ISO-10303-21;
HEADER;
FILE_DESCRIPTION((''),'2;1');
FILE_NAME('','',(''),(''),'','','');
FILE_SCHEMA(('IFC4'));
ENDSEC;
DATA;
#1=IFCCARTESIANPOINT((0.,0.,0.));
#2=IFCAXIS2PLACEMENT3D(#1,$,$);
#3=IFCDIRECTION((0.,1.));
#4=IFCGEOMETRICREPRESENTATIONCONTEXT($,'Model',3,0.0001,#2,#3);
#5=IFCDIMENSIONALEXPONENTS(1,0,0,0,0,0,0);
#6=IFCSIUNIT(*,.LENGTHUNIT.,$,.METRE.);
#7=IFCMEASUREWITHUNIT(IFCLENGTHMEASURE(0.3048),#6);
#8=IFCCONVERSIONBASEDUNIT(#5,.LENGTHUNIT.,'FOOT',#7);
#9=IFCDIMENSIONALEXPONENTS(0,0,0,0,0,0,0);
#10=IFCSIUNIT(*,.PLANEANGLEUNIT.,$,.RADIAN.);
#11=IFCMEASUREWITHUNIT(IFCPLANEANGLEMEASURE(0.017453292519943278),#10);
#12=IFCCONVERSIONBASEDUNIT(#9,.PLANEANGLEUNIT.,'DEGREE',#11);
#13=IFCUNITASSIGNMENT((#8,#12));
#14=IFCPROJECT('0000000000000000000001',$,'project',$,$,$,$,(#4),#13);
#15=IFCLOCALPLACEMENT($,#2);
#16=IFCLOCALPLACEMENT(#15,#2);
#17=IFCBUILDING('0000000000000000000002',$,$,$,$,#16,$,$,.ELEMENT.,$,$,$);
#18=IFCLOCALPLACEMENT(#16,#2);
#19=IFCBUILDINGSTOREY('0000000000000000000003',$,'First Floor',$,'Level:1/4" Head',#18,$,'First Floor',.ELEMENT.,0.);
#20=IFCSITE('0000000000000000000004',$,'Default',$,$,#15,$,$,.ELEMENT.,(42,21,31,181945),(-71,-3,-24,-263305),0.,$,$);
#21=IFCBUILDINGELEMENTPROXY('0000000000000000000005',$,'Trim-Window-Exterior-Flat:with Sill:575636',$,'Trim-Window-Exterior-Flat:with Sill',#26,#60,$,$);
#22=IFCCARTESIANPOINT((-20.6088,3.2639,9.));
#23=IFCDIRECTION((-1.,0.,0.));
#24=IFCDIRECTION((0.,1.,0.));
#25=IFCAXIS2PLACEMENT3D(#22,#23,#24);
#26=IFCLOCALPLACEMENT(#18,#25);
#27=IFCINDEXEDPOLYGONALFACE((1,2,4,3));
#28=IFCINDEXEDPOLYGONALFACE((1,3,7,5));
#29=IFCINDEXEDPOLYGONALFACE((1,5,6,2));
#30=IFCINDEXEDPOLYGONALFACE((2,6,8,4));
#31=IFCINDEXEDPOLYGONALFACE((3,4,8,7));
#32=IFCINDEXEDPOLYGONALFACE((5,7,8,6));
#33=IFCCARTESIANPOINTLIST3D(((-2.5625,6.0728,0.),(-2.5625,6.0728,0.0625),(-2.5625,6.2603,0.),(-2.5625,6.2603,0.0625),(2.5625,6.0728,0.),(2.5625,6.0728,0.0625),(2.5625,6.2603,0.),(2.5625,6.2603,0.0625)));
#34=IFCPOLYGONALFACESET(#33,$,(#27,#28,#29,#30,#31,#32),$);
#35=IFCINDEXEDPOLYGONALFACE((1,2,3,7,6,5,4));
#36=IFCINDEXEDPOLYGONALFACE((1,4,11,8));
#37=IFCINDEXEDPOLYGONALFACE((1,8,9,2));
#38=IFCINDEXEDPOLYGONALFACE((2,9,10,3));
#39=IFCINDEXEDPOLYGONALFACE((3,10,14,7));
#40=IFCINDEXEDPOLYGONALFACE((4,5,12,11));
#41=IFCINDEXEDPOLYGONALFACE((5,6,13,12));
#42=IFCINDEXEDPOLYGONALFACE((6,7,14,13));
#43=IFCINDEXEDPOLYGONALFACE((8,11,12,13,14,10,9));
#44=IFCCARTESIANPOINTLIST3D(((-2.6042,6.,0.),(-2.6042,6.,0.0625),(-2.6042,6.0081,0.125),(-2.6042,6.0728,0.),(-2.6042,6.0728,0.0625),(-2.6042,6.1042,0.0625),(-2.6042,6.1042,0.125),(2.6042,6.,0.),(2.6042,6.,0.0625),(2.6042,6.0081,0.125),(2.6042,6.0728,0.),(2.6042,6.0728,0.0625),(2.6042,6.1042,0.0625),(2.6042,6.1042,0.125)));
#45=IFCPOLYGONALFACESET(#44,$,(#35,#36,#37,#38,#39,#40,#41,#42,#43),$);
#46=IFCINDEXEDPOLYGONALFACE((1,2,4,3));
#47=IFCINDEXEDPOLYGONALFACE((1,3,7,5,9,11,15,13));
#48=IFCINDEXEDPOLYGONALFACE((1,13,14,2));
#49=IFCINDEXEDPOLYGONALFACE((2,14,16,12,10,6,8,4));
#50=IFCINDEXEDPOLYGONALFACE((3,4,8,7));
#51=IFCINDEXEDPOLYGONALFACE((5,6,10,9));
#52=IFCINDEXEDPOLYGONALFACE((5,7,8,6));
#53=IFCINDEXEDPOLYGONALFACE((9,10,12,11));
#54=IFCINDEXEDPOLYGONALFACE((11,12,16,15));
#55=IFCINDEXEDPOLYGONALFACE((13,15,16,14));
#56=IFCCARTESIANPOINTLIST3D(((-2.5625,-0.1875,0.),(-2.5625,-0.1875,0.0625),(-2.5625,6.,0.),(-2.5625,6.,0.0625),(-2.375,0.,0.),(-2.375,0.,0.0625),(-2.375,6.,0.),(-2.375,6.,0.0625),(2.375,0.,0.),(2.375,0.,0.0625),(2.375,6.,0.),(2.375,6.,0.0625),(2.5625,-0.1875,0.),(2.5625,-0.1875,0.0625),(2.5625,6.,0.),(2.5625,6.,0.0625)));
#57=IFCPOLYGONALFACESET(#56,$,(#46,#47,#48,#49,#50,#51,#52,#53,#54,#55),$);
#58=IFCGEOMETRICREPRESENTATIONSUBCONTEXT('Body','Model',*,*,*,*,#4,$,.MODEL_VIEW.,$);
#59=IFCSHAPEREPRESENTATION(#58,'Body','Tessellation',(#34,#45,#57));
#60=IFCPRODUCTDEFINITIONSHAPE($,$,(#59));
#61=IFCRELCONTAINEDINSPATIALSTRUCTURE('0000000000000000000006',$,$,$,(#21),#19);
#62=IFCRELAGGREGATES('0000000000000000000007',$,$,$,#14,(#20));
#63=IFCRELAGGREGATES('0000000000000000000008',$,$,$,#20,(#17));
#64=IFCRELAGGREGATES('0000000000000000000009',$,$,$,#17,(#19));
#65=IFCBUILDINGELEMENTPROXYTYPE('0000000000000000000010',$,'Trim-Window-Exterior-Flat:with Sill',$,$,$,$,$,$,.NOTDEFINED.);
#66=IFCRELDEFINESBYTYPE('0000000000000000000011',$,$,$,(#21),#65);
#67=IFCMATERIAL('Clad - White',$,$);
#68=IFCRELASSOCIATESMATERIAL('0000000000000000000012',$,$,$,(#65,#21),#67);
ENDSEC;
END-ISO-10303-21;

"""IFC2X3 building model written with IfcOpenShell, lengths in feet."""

from ifc_helpers import new_model, entity, si_unit, converted_unit, direction, frame, frame_2d, origin, place, context, subcontext, project, spatial, polyline, rectangle, outline, extrude, source, transform, mapped, material, type_object, type_shapes, element, save


model = new_model("IFC2X3")

# Units and contexts
model_context = context("Model", 3, precision=0.0001, world=origin(), true_north=direction((0.0, 1.0)))
body_context = subcontext(model_context, "Body", "Model", "MODEL_VIEW")
ifc_project = project(units=[converted_unit("LENGTHUNIT", "FOOT", entity("IfcLengthMeasure", 0.3048), si_unit("LENGTHUNIT", "METRE"), dimensions=[1, 0, 0, 0, 0, 0, 0]), converted_unit("PLANEANGLEUNIT", "DEGREE", entity("IfcPlaneAngleMeasure", 0.017453292519943278), si_unit("PLANEANGLEUNIT", "RADIAN"), dimensions=[0, 0, 0, 0, 0, 0, 0])], contexts=[model_context])

# Site, building, storey
site_placement = place(None, origin())
site = spatial("IfcSite", under=ifc_project, at=site_placement, Name="Default", CompositionType="ELEMENT", RefLatitude=(42, 21, 31, 181945), RefLongitude=(-71, -3, -24, -263305), RefElevation=0.0)
building_placement = place(site_placement, origin())
building = spatial("IfcBuilding", under=site, at=building_placement, CompositionType="ELEMENT")
storey_placement = place(building_placement, origin())
storey = spatial("IfcBuildingStorey", under=building, at=storey_placement, Name="First Floor", ObjectType="Level:1/4\" Head", LongName="First Floor", CompositionType="ELEMENT", Elevation=0.0)

# Building element proxy
ifc_material_1 = material(Name="Clad - White")
building_element_proxy_type_1 = type_object("IfcBuildingElementProxyType", Name="Trim-Window-Exterior-Flat:with Sill", PredefinedType="NOTDEFINED", material=ifc_material_1)
shared_shape_1 = source(origin(), body_context, "Body", "SweptSolid", [
    extrude(rectangle(XDim=0.1875, YDim=5.125, at=frame_2d((0.0, 0.0), x_axis=(1.0, 0.0))), frame((0.0, 6.1665, 0.0), z_axis=(0.0, 0.0, 1.0), x_axis=(0.0, 1.0, 0.0)), (0.0, 0.0, 1.0), 0.0625),
    extrude(outline(polyline([(-0.0525, -0.0625), (0.0436, -0.0625), (0.0517, 0.0), (0.0517, 0.0625), (-0.0211, 0.0625), (-0.0211, 0.0), (-0.0525, 0.0), (-0.0525, -0.0625)])), frame((-2.6042, 6.0517, 0.0625), z_axis=(1.0, 0.0, 0.0), x_axis=(0.0, -1.0, 0.0)), (0.0, 0.0, 1.0), 5.2083),
    extrude(outline(polyline([(-2.5625, -3.1406), (2.5625, -3.1406), (2.5625, 3.0469), (2.375, 3.0469), (2.375, -2.9531), (-2.375, -2.9531), (-2.375, 3.0469), (-2.5625, 3.0469), (-2.5625, -3.1406)])), frame((0.0, 2.9531, 0.0)), (0.0, 0.0, 1.0), 0.0625),
])
type_shapes(building_element_proxy_type_1, [shared_shape_1])
proxy_1_placement = place(storey_placement, frame((-20.6088, 3.2639, 9.0), z_axis=(-1.0, 0.0, 0.0), x_axis=(0.0, 1.0, 0.0)))
element("IfcBuildingElementProxy", 1, at=proxy_1_placement, inside=storey, type_object=building_element_proxy_type_1, material=ifc_material_1, Name="Trim-Window-Exterior-Flat:with Sill:575636", ObjectType="Trim-Window-Exterior-Flat:with Sill", context=body_context, shape_type="MappedRepresentation", body=[
    mapped(shared_shape_1, transform((0.0, 0.0, 0.0), scale=1.0)),
])

save(model, "model.ifc")
